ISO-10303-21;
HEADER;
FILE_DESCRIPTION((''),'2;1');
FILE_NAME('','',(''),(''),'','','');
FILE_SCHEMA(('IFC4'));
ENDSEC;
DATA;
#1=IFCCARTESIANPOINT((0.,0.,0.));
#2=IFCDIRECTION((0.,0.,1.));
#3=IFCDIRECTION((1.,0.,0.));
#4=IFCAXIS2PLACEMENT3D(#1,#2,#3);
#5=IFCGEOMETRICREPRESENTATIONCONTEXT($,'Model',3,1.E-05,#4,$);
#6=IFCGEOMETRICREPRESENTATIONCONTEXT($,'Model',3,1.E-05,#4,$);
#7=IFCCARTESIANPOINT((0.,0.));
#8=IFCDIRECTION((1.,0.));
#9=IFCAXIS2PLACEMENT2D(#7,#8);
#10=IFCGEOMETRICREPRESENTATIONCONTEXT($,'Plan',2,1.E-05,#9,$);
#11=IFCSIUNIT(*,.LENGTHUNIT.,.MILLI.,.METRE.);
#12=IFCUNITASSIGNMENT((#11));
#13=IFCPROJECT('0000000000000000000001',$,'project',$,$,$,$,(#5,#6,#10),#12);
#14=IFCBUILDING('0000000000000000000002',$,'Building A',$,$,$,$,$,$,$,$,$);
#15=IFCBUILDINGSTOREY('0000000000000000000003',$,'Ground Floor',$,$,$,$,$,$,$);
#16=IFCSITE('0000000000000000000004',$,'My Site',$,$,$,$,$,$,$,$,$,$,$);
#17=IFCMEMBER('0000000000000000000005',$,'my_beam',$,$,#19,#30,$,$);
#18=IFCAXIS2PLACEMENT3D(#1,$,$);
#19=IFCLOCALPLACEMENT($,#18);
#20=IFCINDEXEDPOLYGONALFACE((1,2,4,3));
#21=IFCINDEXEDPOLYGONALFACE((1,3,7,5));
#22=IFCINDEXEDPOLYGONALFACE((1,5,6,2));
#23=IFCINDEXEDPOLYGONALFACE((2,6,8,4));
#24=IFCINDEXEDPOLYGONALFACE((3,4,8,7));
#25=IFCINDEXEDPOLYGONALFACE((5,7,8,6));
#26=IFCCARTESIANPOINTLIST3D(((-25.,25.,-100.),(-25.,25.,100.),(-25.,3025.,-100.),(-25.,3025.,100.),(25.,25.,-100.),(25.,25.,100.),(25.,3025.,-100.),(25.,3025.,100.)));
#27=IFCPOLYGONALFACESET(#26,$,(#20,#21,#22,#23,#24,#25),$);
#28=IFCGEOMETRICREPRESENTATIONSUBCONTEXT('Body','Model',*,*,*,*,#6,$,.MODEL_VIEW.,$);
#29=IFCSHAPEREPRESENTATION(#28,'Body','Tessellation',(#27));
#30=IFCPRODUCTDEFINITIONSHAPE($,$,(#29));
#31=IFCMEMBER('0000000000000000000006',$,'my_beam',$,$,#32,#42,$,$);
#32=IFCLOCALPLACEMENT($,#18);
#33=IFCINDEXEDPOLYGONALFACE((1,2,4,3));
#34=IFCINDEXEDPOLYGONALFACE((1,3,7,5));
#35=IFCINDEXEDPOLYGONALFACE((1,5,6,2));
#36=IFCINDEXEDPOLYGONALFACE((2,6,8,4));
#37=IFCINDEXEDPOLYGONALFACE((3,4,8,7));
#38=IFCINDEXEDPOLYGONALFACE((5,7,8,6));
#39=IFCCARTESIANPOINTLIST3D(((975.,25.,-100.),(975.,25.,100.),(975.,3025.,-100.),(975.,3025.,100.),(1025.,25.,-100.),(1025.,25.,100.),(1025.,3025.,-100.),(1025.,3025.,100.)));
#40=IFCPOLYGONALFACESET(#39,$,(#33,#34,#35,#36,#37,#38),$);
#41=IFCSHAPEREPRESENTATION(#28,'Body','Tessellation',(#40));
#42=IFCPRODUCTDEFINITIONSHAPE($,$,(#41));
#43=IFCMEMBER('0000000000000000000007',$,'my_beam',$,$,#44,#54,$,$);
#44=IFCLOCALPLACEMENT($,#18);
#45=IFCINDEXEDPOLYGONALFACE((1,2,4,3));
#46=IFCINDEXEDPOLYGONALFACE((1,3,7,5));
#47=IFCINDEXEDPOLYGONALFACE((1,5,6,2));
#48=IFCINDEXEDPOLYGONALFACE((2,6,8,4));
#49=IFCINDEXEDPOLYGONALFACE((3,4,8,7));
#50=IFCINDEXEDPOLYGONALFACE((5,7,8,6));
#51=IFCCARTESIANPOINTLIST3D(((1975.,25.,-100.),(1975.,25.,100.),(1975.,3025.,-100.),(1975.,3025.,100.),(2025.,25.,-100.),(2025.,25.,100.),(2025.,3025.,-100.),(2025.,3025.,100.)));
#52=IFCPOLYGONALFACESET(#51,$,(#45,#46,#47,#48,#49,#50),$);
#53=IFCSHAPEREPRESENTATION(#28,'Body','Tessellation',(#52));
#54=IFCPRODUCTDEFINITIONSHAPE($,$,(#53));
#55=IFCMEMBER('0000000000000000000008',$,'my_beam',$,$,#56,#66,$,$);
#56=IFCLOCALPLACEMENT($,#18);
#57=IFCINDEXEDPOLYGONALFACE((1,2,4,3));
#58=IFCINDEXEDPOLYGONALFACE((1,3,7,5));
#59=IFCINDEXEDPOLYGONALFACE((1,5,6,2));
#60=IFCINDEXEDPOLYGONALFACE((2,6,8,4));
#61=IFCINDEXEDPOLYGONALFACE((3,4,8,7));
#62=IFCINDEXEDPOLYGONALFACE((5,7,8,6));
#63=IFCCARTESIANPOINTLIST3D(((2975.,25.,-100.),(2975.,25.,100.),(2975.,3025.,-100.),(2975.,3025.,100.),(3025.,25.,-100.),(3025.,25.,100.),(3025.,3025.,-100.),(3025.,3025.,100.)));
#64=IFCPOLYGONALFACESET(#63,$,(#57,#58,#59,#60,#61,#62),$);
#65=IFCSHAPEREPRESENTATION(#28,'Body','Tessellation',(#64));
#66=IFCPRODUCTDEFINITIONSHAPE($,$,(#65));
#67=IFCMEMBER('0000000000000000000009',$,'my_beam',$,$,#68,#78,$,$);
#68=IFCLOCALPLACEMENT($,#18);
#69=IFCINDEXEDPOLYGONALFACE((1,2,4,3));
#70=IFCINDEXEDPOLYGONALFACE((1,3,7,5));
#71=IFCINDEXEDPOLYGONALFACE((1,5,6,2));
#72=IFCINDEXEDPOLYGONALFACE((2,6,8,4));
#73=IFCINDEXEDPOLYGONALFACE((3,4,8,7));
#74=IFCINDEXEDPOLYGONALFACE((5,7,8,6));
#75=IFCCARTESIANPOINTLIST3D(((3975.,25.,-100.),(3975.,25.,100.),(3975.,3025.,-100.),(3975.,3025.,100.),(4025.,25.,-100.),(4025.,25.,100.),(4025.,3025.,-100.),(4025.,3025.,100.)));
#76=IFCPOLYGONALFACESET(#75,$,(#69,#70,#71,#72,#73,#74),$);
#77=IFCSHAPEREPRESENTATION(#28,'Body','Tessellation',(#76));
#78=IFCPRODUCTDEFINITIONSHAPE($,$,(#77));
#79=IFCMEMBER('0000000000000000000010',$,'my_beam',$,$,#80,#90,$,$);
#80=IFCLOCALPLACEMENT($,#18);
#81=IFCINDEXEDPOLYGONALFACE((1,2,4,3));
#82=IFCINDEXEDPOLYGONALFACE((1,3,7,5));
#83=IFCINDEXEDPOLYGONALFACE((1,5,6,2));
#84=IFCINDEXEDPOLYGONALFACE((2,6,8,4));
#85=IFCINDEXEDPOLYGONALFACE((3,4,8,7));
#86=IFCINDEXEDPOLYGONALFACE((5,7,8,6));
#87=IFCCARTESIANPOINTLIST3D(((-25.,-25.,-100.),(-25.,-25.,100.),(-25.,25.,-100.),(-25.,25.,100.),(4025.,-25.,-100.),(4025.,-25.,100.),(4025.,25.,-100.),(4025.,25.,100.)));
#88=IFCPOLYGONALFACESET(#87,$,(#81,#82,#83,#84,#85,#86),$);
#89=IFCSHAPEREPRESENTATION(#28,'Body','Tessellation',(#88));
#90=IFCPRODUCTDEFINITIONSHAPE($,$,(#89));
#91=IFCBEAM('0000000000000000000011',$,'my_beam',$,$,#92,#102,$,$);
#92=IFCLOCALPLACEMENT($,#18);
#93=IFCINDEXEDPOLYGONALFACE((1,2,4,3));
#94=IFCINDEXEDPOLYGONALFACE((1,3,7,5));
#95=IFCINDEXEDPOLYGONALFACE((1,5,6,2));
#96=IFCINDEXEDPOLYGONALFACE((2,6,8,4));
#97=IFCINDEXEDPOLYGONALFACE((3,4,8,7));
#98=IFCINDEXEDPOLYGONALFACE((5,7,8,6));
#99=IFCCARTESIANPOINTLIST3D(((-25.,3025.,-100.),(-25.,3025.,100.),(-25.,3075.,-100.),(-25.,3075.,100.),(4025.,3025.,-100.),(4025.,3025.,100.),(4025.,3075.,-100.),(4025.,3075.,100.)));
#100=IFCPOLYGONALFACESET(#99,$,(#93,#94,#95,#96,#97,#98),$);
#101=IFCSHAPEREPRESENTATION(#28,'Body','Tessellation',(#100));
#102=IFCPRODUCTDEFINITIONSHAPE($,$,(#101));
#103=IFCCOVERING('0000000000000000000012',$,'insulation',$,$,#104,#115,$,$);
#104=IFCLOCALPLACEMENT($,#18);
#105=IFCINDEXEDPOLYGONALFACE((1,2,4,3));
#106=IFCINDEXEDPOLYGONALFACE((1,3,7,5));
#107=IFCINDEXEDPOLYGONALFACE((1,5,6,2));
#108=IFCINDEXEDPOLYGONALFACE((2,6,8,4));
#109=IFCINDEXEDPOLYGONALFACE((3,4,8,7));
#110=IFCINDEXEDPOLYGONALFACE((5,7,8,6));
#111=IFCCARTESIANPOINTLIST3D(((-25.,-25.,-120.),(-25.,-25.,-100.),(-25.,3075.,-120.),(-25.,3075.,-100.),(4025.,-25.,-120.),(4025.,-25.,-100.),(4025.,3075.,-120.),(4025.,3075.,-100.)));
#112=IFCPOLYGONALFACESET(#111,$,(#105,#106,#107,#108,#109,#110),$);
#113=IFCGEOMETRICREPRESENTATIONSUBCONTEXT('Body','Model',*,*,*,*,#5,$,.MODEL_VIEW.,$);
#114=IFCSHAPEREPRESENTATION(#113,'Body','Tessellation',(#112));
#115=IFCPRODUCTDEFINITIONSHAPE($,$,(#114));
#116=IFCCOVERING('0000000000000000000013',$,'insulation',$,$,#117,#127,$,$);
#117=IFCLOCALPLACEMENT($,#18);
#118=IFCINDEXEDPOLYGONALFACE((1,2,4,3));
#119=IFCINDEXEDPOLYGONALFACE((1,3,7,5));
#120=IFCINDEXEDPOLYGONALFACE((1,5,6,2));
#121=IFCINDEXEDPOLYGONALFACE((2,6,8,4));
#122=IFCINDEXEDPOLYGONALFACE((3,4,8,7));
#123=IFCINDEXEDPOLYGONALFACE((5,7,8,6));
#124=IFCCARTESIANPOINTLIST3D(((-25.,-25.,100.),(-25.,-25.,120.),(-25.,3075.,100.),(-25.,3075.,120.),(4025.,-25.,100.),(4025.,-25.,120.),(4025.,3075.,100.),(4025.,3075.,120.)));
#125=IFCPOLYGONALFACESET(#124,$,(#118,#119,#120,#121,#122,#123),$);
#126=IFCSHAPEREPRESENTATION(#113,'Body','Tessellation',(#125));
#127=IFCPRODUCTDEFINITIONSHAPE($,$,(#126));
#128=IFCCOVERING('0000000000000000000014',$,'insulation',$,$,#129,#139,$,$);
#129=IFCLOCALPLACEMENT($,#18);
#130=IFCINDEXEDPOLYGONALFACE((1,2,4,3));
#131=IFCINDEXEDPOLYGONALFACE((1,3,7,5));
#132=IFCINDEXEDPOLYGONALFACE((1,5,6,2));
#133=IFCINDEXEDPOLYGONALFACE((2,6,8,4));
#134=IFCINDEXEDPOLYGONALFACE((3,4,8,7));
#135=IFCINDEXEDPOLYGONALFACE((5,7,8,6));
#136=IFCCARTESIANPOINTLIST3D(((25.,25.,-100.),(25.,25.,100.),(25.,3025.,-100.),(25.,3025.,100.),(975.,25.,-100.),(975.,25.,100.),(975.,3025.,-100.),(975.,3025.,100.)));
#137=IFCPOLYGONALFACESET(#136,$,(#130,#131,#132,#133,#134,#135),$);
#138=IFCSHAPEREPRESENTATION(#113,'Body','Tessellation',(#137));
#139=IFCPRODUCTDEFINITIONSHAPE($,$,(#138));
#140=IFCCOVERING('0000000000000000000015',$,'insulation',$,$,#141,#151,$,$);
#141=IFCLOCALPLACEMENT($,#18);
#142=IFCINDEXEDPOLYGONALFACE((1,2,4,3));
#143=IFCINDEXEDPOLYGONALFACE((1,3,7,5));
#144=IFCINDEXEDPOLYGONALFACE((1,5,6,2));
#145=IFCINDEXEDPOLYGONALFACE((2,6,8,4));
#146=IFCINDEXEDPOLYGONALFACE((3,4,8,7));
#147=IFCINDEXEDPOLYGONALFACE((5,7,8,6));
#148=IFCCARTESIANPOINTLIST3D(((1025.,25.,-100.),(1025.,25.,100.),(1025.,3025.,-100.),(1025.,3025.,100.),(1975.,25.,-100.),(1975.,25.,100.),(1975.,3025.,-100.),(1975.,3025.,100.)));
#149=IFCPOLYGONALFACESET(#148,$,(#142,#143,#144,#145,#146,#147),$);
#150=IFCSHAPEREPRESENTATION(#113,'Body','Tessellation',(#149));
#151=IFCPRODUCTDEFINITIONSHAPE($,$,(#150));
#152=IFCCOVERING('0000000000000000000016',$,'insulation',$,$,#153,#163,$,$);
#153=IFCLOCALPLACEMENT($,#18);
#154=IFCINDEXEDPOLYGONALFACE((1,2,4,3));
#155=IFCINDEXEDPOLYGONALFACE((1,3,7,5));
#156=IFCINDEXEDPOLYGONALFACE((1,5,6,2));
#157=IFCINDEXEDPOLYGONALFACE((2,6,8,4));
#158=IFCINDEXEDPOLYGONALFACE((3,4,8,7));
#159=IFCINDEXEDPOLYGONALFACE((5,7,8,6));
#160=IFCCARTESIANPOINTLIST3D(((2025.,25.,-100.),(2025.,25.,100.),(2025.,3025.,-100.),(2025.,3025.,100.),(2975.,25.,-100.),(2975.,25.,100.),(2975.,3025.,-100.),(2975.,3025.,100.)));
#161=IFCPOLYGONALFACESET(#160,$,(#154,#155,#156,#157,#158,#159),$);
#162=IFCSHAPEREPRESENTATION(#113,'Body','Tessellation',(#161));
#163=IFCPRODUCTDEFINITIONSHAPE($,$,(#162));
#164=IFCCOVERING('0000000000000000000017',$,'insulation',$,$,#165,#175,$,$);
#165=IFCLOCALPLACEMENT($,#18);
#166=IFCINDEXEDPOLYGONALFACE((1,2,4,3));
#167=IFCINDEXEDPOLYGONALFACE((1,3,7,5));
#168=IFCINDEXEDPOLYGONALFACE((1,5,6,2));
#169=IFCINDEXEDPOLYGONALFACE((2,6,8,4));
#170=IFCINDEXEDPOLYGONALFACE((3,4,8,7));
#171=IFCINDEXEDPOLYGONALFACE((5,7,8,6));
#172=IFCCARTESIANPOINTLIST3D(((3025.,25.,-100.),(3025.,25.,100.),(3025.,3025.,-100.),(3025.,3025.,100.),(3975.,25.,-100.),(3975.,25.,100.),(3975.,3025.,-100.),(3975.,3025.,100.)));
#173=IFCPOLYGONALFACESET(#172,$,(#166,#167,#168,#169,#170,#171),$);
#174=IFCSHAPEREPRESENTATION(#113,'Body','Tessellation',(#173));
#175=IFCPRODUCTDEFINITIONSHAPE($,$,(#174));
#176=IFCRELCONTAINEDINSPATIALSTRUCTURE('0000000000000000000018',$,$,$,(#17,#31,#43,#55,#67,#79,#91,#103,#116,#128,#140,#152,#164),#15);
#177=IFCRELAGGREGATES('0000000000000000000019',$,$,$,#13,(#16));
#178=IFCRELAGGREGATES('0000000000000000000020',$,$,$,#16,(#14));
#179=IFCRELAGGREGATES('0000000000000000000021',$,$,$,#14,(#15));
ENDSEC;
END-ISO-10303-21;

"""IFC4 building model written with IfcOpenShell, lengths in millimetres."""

from ifc_helpers import new_model, si_unit, frame, origin_with_axes, origin_2d_with_axis, place, context, subcontext, project, spatial, indexed_curve, rectangle, outline, extrude, element, save


model = new_model("IFC4")

# Units and contexts
model_context_1 = context("Model", 3, precision=1e-05, world=origin_with_axes())
model_context_2 = context("Model", 3, precision=1e-05, world=origin_with_axes())
plan_context = context("Plan", 2, precision=1e-05, world=origin_2d_with_axis())
body_context_1 = subcontext(model_context_1, "Body", "Model", "MODEL_VIEW")
body_context_2 = subcontext(model_context_2, "Body", "Model", "MODEL_VIEW")
ifc_project = project(units=[si_unit("LENGTHUNIT", "METRE", prefix="MILLI")], contexts=[model_context_1, model_context_2, plan_context])

# Site, building, storey
site = spatial("IfcSite", under=ifc_project, Name="My Site")
building = spatial("IfcBuilding", under=site, Name="Building A")
storey = spatial("IfcBuildingStorey", under=building, Name="Ground Floor")

# Members
for number, where, z_axis, x_axis, name in (
    (1, (0.0, 25.0, 0.0), (0.0, 1.0, 0.0), (1.0, 1.0, 0.0), "my_beam"),
    (2, (1000.0, 25.0, 0.0), (0.0, 1.0, 0.0), (1.0, 1.0, 0.0), "my_beam"),
    (3, (2000.0, 25.0, 0.0), (0.0, 1.0, 0.0), (1.0, 1.0, 0.0), "my_beam"),
    (4, (3000.0, 25.0, 0.0), (0.0, 1.0, 0.0), (1.0, 1.0, 0.0), "my_beam"),
    (5, (4000.0, 25.0, 0.0), (0.0, 1.0, 0.0), (1.0, 1.0, 0.0), "my_beam"),
):
    element("IfcMember", number, at=place(None, frame(where, z_axis=z_axis, x_axis=x_axis)), inside=storey, Name=name, context=body_context_2, shape_type="SweptSolid", body=[
        extrude(rectangle(XDim=50.0, YDim=200.0), origin_with_axes(), (0.0, 0.0, 1.0), 3000.0),
    ])
member_placement = place(None, frame((-25.0, 0.0, 0.0), z_axis=(1.0, 0.0, 0.0), x_axis=(1.0, 1.0, 0.0)))
element("IfcMember", 6, at=member_placement, inside=storey, Name="my_beam", context=body_context_2, shape_type="SweptSolid", body=[
    extrude(rectangle(XDim=50.0, YDim=200.0), origin_with_axes(), (0.0, 0.0, 1.0), 4050.0),
])

# Beam
beam_placement = place(None, frame((-25.0, 3050.0, 0.0), z_axis=(1.0, 0.0, 0.0), x_axis=(1.0, 1.0, 0.0)))
element("IfcBeam", 7, at=beam_placement, inside=storey, Name="my_beam", context=body_context_2, shape_type="SweptSolid", body=[
    extrude(rectangle(XDim=50.0, YDim=200.0), origin_with_axes(), (0.0, 0.0, 1.0), 4050.0),
])

# Coverings
for number, where, z_axis, x_axis, name in (
    (8, (-25.0, -25.0, -100.0), (0.0, 1.0, 0.0), (1.0, 1.0, 0.0), "insulation"),
    (9, (-25.0, -25.0, 120.0), (0.0, 1.0, 0.0), (1.0, 1.0, 0.0), "insulation"),
):
    element("IfcCovering", number, at=place(None, frame(where, z_axis=z_axis, x_axis=x_axis)), inside=storey, Name=name, context=body_context_1, shape_type="SweptSolid", body=[
        extrude(outline(indexed_curve([(0.0, 0.0), (0.0, 20.0), (4050.0, 20.0), (4050.0, 0.0), (0.0, 0.0)], self_intersect=False)), origin_with_axes(), (0.0, 0.0, 1.0), 3100.0),
    ])
for number, where, z_axis, x_axis, name in (
    (10, (25.0, 25.0, 100.0), (0.0, 1.0, 0.0), (1.0, 1.0, 0.0), "insulation"),
    (11, (1025.0, 25.0, 100.0), (0.0, 1.0, 0.0), (1.0, 1.0, 0.0), "insulation"),
    (12, (2025.0, 25.0, 100.0), (0.0, 1.0, 0.0), (1.0, 1.0, 0.0), "insulation"),
    (13, (3025.0, 25.0, 100.0), (0.0, 1.0, 0.0), (1.0, 1.0, 0.0), "insulation"),
):
    element("IfcCovering", number, at=place(None, frame(where, z_axis=z_axis, x_axis=x_axis)), inside=storey, Name=name, context=body_context_1, shape_type="SweptSolid", body=[
        extrude(outline(indexed_curve([(0.0, 0.0), (0.0, 200.0), (950.0, 200.0), (950.0, 0.0), (0.0, 0.0)], self_intersect=False)), origin_with_axes(), (0.0, 0.0, 1.0), 3000.0),
    ])

save(model, "model.ifc")
